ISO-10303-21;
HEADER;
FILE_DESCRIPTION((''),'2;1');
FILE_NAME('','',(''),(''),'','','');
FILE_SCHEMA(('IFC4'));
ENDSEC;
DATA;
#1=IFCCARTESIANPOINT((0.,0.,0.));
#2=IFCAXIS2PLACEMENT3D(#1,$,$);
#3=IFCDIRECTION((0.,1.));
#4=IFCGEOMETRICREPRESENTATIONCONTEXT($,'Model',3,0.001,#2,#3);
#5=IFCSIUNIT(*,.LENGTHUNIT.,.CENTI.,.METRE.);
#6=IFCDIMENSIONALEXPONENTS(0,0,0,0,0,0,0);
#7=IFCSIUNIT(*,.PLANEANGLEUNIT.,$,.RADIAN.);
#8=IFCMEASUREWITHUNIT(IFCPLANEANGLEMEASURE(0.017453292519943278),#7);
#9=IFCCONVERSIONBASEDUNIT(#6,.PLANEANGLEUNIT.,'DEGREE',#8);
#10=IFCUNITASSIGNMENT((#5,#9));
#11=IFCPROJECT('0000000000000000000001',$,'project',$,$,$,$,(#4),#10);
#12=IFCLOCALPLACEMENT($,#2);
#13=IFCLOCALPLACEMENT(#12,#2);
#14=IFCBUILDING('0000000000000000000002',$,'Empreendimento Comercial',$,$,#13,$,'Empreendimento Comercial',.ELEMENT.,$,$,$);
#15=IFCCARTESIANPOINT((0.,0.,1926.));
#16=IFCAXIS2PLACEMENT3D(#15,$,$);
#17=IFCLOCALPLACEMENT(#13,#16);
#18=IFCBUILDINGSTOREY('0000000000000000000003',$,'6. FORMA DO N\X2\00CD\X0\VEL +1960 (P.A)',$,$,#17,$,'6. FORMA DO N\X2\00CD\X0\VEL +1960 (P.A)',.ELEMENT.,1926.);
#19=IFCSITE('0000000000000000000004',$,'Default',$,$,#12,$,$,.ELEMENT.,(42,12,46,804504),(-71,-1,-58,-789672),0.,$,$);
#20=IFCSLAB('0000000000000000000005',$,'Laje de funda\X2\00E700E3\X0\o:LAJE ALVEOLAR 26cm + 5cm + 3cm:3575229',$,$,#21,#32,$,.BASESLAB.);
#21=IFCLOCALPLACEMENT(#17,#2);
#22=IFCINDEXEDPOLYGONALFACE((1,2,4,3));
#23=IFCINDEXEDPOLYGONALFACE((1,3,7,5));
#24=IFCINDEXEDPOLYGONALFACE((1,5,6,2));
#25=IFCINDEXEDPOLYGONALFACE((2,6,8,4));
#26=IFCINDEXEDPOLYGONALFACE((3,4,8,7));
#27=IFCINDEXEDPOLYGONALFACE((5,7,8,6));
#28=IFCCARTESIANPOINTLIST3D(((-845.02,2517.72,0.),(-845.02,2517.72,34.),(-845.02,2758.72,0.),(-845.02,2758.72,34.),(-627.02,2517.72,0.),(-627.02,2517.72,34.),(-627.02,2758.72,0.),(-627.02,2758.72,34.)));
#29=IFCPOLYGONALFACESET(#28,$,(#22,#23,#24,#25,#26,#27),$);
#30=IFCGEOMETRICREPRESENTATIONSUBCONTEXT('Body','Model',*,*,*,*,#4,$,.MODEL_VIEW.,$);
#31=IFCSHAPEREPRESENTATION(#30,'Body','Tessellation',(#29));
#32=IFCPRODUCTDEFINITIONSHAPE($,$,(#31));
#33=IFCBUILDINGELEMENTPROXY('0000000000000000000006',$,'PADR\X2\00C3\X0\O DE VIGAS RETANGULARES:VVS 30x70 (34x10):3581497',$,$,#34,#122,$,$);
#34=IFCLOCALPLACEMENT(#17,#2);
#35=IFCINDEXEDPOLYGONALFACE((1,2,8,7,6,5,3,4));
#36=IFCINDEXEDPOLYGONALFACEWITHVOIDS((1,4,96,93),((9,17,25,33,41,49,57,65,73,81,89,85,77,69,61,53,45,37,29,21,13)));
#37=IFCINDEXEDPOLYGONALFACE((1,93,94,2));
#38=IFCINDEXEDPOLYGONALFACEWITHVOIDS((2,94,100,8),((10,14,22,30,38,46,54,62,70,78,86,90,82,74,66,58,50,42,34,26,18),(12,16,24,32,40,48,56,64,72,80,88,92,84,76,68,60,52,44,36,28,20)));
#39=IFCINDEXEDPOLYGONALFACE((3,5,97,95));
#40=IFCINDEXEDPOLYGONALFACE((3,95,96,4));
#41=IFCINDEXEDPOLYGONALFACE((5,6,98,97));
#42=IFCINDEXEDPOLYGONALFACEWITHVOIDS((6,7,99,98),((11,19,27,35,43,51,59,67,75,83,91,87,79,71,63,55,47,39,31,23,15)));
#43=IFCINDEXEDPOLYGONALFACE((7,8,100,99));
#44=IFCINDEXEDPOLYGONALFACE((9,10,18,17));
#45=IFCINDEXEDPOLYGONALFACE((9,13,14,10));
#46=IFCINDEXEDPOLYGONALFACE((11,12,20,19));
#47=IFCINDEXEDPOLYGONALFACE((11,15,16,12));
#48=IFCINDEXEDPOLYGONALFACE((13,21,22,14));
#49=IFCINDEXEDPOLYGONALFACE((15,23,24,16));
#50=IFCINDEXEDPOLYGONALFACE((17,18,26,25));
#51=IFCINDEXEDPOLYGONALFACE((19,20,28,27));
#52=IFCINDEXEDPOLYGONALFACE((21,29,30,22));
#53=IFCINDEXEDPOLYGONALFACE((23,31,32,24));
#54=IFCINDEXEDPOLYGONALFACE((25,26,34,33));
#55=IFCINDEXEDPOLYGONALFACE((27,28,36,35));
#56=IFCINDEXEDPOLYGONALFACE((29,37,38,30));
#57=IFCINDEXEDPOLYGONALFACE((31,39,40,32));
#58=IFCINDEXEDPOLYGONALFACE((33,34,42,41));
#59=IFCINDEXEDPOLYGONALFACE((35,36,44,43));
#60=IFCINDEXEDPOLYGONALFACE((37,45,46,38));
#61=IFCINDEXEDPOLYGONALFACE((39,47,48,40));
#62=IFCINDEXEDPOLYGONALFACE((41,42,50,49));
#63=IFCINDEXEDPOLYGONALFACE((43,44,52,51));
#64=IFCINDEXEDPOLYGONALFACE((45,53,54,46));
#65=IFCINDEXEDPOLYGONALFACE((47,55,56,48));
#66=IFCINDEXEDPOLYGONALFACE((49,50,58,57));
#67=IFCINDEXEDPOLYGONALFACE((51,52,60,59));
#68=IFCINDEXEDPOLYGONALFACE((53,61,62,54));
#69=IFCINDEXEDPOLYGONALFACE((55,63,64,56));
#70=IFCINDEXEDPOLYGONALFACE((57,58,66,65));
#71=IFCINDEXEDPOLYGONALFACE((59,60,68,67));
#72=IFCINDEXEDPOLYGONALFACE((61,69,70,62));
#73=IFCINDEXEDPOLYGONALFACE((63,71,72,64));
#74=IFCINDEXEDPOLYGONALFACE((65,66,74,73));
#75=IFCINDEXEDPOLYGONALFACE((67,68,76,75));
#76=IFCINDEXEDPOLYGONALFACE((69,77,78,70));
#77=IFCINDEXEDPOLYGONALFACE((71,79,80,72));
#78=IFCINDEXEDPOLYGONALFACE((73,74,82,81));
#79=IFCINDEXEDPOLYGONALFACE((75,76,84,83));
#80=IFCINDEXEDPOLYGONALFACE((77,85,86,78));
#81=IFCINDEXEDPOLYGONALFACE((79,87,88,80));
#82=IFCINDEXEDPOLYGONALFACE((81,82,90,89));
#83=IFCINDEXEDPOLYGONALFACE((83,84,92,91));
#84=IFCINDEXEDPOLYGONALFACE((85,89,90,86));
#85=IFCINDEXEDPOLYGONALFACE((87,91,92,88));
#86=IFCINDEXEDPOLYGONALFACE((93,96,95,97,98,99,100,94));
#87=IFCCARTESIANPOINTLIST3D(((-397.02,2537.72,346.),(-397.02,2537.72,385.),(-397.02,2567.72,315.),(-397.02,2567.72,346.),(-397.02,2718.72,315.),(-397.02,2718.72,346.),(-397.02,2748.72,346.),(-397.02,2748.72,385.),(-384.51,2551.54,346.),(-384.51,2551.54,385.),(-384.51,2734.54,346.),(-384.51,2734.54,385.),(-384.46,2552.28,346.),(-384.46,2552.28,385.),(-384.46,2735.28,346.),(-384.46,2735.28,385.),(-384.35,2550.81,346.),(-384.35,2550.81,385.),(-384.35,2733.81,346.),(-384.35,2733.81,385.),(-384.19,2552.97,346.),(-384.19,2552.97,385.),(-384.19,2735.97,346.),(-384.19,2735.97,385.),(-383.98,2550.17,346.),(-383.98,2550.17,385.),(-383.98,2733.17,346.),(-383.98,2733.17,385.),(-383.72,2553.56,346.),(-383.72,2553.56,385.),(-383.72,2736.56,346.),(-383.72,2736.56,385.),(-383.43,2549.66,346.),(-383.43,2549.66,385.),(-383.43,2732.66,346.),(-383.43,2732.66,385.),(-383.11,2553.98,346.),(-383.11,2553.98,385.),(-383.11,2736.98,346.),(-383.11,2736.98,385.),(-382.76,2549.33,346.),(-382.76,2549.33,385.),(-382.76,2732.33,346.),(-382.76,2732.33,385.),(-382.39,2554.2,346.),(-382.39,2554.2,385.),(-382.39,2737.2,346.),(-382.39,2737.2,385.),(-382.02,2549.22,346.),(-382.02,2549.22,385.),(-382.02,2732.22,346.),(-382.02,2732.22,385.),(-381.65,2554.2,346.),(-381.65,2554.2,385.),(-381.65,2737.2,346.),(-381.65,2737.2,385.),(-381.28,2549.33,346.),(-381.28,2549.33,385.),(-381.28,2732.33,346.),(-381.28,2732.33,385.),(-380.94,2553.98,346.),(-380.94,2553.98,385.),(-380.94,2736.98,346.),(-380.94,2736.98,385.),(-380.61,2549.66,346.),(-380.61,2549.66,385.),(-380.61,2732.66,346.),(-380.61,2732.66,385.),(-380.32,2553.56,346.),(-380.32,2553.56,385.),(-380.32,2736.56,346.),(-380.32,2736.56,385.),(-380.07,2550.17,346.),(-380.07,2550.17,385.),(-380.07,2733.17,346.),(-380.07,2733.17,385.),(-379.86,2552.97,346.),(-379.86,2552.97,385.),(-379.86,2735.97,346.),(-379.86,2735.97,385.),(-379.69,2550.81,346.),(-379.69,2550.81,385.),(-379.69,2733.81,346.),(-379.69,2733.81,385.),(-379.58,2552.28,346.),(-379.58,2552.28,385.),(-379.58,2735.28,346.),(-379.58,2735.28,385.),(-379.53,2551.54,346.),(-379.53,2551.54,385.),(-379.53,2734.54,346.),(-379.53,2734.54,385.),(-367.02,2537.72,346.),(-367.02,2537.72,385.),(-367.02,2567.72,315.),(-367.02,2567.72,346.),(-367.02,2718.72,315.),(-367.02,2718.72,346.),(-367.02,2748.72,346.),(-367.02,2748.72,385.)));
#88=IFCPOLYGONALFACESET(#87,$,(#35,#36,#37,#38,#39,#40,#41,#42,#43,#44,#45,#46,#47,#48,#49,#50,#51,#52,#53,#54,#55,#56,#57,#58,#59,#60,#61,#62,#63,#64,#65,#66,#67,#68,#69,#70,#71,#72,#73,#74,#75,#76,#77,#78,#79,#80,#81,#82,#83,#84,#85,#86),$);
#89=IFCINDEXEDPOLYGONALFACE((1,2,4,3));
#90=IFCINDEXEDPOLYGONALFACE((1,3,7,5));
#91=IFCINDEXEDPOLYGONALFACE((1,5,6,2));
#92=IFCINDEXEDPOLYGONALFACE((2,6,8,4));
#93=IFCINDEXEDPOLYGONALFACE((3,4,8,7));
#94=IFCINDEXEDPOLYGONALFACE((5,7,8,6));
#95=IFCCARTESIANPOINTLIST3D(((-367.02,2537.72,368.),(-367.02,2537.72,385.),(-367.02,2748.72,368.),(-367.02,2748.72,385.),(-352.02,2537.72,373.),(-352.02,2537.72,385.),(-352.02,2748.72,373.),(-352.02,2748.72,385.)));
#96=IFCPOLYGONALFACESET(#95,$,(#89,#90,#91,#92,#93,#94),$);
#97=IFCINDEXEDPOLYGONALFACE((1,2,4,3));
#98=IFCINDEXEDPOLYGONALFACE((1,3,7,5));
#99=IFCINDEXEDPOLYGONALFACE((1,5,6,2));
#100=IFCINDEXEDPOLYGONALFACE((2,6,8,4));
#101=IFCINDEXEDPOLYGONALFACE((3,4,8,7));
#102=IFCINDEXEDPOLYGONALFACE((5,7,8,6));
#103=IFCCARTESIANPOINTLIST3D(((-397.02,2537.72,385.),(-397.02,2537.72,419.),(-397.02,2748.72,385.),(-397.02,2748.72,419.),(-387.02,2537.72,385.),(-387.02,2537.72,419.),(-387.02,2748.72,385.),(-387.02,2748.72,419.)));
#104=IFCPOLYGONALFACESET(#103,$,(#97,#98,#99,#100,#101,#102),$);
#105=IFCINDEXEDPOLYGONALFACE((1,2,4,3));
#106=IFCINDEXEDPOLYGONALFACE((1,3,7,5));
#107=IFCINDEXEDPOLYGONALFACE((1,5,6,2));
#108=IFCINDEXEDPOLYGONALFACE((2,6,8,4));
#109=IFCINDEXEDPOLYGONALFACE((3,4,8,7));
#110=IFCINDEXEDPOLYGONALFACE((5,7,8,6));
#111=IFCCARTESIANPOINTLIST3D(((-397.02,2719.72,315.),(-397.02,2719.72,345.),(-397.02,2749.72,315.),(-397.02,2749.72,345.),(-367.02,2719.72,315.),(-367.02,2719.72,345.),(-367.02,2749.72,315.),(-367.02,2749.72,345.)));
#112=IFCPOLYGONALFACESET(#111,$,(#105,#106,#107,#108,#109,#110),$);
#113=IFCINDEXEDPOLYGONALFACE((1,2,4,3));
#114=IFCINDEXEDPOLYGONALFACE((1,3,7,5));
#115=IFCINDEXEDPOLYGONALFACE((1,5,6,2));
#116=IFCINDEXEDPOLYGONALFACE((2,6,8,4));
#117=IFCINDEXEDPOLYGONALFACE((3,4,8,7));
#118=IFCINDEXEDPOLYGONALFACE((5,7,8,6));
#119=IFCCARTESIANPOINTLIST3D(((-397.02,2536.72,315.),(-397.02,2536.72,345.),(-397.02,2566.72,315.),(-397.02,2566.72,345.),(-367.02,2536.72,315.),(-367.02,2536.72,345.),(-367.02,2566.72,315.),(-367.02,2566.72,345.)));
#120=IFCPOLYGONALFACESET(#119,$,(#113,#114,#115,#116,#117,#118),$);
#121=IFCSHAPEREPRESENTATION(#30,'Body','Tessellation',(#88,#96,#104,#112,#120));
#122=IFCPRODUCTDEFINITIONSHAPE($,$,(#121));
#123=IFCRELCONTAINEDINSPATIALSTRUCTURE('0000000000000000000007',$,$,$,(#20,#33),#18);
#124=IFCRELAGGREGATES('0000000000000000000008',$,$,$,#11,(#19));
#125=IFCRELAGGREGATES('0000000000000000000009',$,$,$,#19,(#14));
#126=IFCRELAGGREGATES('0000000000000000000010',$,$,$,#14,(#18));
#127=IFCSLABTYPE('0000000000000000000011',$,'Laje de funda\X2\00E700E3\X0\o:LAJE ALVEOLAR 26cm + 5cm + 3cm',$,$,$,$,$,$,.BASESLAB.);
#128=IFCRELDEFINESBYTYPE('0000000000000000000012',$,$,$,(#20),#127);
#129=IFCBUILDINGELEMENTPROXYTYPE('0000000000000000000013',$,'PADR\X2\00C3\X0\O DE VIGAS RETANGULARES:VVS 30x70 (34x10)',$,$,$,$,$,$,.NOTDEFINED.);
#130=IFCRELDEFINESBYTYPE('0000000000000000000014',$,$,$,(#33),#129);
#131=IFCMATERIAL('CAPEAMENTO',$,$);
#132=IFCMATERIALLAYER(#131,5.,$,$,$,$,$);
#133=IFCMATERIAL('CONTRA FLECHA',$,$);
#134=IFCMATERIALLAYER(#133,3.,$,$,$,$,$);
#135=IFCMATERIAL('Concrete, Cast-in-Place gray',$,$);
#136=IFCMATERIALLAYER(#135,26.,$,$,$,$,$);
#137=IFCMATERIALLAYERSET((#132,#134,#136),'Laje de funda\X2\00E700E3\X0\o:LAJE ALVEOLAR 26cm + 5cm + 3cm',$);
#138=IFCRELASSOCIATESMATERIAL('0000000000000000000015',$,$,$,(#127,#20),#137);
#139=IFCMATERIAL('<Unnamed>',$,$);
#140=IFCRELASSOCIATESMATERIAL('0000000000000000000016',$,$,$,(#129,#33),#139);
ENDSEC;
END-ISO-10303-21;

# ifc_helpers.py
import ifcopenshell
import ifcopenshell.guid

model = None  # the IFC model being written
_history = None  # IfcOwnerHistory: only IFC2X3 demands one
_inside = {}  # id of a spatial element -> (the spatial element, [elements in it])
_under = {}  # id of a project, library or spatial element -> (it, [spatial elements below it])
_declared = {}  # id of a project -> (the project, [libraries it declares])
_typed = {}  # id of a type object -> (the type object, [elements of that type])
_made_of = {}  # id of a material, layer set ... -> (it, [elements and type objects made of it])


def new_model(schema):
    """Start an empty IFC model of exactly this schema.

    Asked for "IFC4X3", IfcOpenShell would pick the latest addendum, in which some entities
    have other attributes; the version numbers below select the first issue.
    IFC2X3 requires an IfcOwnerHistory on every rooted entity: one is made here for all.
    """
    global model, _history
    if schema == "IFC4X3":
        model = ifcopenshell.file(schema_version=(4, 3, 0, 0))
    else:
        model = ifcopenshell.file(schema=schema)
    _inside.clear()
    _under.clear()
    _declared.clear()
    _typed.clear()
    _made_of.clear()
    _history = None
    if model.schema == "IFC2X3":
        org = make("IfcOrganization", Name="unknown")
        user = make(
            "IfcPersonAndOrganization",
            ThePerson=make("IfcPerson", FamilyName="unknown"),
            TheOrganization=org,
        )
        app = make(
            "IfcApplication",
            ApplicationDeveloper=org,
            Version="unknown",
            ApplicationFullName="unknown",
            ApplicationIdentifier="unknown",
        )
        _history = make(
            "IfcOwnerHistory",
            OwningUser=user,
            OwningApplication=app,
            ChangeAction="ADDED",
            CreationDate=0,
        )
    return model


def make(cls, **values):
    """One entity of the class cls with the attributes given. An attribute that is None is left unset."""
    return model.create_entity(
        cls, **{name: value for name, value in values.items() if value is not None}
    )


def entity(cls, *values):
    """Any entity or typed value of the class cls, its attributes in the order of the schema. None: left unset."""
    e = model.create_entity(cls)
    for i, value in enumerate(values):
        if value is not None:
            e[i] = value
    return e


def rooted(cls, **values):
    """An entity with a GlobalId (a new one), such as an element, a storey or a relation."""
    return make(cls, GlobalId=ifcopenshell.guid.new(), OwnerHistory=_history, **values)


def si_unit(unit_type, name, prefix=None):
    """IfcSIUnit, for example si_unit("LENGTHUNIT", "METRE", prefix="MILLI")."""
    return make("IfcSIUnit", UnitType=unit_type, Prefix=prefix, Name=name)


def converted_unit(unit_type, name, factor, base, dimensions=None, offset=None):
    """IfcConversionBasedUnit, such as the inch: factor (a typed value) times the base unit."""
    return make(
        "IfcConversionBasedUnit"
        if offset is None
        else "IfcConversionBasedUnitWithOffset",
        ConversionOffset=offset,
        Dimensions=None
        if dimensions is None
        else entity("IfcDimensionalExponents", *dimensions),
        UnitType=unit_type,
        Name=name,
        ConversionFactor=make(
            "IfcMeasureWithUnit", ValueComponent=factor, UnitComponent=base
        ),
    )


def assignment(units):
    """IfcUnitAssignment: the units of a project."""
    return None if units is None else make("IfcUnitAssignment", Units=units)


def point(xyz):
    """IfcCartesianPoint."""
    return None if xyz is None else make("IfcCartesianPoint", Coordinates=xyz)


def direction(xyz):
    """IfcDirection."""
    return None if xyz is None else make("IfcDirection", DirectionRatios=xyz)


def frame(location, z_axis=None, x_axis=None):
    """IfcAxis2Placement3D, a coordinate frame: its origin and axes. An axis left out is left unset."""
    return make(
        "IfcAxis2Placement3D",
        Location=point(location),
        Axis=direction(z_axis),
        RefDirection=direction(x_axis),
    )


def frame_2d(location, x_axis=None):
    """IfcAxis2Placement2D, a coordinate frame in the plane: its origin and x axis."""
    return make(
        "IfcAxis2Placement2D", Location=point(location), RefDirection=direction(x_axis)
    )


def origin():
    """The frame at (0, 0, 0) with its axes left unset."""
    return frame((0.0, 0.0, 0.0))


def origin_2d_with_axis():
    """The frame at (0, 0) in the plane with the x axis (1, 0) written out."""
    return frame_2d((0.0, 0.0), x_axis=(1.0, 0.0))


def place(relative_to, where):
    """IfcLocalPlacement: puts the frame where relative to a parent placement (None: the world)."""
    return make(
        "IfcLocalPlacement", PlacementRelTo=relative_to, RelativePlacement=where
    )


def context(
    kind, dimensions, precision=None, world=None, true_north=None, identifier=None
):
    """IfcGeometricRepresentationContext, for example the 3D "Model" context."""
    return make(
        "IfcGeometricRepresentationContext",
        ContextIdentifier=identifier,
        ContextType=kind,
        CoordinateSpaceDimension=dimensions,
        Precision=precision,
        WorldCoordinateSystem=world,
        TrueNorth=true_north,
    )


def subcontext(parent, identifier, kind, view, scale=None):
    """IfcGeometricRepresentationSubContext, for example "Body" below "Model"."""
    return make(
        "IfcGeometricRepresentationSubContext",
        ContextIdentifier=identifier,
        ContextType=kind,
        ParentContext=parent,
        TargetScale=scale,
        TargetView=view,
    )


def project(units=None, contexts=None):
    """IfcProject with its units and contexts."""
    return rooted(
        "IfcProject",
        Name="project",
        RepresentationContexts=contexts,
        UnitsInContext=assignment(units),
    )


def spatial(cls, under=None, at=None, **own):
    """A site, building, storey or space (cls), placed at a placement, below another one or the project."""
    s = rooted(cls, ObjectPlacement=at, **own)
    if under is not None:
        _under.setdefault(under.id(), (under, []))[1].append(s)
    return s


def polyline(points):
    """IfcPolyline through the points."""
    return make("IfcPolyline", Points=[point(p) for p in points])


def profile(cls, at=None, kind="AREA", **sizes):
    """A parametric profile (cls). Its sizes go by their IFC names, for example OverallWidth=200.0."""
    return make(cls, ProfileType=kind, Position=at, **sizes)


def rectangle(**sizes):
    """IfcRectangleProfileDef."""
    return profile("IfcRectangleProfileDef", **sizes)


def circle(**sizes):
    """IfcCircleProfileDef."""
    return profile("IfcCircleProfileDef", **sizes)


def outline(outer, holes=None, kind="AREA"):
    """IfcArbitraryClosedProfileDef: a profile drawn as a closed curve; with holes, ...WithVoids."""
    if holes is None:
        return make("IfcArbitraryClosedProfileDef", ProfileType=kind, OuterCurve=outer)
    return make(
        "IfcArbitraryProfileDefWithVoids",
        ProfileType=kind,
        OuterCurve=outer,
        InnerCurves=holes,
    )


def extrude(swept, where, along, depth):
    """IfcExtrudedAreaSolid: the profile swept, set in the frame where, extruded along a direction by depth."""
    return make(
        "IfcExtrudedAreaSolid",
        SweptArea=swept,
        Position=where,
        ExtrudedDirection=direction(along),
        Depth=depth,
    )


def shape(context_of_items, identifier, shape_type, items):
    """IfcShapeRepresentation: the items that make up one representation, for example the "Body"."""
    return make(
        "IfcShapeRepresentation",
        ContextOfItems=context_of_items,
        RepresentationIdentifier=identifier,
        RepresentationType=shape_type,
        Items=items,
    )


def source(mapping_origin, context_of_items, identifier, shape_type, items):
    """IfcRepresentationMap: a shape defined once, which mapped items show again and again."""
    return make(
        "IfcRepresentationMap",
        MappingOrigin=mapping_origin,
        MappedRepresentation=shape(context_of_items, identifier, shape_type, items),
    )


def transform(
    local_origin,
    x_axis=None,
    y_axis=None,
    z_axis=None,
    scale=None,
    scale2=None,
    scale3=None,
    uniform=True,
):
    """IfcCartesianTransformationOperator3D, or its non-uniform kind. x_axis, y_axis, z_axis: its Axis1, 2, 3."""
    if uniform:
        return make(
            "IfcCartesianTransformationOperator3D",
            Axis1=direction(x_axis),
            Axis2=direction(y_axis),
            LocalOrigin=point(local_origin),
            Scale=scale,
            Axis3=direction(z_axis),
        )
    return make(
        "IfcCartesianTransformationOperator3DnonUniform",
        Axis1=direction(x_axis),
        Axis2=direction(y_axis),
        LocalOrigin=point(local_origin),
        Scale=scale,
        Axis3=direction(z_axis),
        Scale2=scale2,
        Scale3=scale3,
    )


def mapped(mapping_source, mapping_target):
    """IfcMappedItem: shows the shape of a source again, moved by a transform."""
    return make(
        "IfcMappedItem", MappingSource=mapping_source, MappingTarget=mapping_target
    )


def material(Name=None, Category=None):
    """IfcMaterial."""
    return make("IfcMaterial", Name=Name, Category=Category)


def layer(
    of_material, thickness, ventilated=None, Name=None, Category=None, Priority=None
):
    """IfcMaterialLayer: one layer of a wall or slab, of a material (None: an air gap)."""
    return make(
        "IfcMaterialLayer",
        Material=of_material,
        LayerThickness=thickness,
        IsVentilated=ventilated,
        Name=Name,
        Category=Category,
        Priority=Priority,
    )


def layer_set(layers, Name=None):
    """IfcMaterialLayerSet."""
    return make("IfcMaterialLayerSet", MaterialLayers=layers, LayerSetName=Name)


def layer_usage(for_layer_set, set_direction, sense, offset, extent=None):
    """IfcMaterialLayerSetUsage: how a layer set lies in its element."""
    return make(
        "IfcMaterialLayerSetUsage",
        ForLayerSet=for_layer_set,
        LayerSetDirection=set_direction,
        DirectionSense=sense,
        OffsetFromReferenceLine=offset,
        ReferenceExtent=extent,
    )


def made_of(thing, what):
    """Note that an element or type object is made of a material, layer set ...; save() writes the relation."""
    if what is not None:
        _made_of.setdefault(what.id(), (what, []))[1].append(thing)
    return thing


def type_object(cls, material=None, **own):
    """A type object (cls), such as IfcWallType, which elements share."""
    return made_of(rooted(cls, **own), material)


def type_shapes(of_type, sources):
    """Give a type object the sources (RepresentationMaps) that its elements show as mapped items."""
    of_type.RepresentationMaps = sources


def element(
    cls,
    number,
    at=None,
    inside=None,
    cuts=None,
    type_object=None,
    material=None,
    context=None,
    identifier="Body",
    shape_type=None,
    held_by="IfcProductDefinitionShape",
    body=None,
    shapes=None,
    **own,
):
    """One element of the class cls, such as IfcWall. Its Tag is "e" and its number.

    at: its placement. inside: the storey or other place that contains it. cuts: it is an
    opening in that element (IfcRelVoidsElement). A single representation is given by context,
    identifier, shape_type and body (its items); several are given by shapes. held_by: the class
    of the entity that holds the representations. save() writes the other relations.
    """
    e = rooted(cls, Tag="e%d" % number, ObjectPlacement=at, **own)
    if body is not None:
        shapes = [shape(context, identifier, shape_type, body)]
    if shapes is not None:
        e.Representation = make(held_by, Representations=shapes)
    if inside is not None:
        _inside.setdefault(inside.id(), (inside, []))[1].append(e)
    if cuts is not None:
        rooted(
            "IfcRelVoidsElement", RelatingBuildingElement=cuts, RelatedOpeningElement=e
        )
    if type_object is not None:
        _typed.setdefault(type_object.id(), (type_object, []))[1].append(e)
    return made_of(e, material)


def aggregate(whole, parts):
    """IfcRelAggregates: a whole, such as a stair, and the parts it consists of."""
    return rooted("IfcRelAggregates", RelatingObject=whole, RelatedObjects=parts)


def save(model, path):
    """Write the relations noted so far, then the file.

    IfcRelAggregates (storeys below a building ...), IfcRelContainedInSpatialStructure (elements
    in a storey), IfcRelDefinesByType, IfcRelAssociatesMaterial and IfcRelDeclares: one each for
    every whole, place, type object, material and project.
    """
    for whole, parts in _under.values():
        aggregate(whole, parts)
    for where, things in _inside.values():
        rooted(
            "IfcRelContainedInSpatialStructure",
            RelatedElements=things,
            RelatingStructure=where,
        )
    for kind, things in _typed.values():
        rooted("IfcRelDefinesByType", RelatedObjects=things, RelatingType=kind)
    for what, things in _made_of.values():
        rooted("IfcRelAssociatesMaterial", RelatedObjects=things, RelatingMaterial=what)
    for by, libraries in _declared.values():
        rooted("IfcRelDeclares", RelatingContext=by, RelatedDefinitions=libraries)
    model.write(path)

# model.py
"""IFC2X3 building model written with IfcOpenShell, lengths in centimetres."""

from ifc_helpers import new_model, entity, si_unit, converted_unit, direction, frame, frame_2d, origin, origin_2d_with_axis, place, context, subcontext, project, spatial, polyline, rectangle, circle, outline, extrude, source, transform, mapped, material, layer, layer_set, layer_usage, type_object, type_shapes, element, save


model = new_model("IFC2X3")

# Units and contexts
model_context = context("Model", 3, precision=0.001, world=origin(), true_north=direction((0.0, 1.0)))
body_context = subcontext(model_context, "Body", "Model", "MODEL_VIEW")
ifc_project = project(units=[si_unit("LENGTHUNIT", "METRE", prefix="CENTI"), converted_unit("PLANEANGLEUNIT", "DEGREE", entity("IfcPlaneAngleMeasure", 0.017453292519943278), si_unit("PLANEANGLEUNIT", "RADIAN"), dimensions=[0, 0, 0, 0, 0, 0, 0])], contexts=[model_context])

# Site, building, storey
site_placement = place(None, origin())
site = spatial("IfcSite", under=ifc_project, at=site_placement, Name="Default", CompositionType="ELEMENT", RefLatitude=(42, 12, 46, 804504), RefLongitude=(-71, -1, -58, -789672), RefElevation=0.0)
building_placement = place(site_placement, origin())
building = spatial("IfcBuilding", under=site, at=building_placement, Name="Empreendimento Comercial", LongName="Empreendimento Comercial", CompositionType="ELEMENT")
storey_placement = place(building_placement, frame((0.0, 0.0, 1926.0)))
storey = spatial("IfcBuildingStorey", under=building, at=storey_placement, Name="6. FORMA DO NÍVEL +1960 (P.A)", LongName="6. FORMA DO NÍVEL +1960 (P.A)", CompositionType="ELEMENT", Elevation=1926.0)

# Slab
ifc_material_1 = material(Name="CAPEAMENTO")
ifc_layer_1 = layer(ifc_material_1, 5.0)
ifc_material_2 = material(Name="CONTRA FLECHA")
ifc_layer_2 = layer(ifc_material_2, 3.0)
ifc_material_3 = material(Name="Concrete, Cast-in-Place gray")
ifc_layer_3 = layer(ifc_material_3, 26.0)
ifc_layer_set_1 = layer_set([ifc_layer_1, ifc_layer_2, ifc_layer_3], Name="Laje de fundação:LAJE ALVEOLAR 26cm + 5cm + 3cm")
ifc_layer_usage_1 = layer_usage(ifc_layer_set_1, "AXIS3", "POSITIVE", 0.0)
slab_type_1 = type_object("IfcSlabType", Name="Laje de fundação:LAJE ALVEOLAR 26cm + 5cm + 3cm", PredefinedType="BASESLAB", material=ifc_layer_set_1)
slab_1_placement = place(storey_placement, origin())
element("IfcSlab", 1, at=slab_1_placement, inside=storey, type_object=slab_type_1, material=ifc_layer_usage_1, Name="Laje de fundação:LAJE ALVEOLAR 26cm + 5cm + 3cm:3575229", PredefinedType="BASESLAB", context=body_context, shape_type="SweptSolid", body=[
    extrude(rectangle(XDim=241.0, YDim=218.0, at=origin_2d_with_axis()), frame((-736.02, 2638.22, 34.0), z_axis=(0.0, 0.0, -1.0), x_axis=(0.0, 1.0, 0.0)), (0.0, 0.0, 1.0), 34.0),
])

# Building element proxy, openings
ifc_material_4 = material(Name="<Unnamed>")
building_element_proxy_type_1 = type_object("IfcBuildingElementProxyType", Name="PADRÃO DE VIGAS RETANGULARES:VVS 30x70 (34x10)", PredefinedType="NOTDEFINED", material=ifc_material_4)
shared_shape_1 = source(origin(), body_context, "Body", "SweptSolid", [
    extrude(outline(polyline([(-105.5, -37.0), (105.5, -37.0), (105.5, 2.0), (75.5, 2.0), (75.5, 33.0), (-75.5, 33.0), (-75.5, 2.0), (-105.5, 2.0), (-105.5, -37.0)])), frame((-397.02, 2643.22, 2274.0), z_axis=(1.0, 0.0, 0.0), x_axis=(0.0, -1.0, 0.0)), (0.0, 0.0, 1.0), 30.0),
    extrude(outline(polyline([(-7.25, -7.5), (4.75, -7.5), (9.75, 7.5), (-7.25, 7.5), (-7.25, -7.5)])), frame((-359.52, 2537.72, 2303.75), z_axis=(0.0, 1.0, 0.0), x_axis=(0.0, 0.0, -1.0)), (0.0, 0.0, 1.0), 211.0),
    extrude(rectangle(XDim=211.0, YDim=10.0, at=frame_2d((0.0, 0.0), x_axis=(1.0, 0.0))), frame((-392.02, 2643.22, 2311.0), z_axis=(0.0, 0.0, 1.0), x_axis=(0.0, 1.0, 0.0)), (0.0, 0.0, 1.0), 34.0),
    extrude(rectangle(XDim=30.0, YDim=30.0, at=frame_2d((0.0, 0.0), x_axis=(1.0, 0.0))), frame((-382.02, 2734.72, 2241.0), z_axis=(0.0, 0.0, 1.0), x_axis=(0.0, 1.0, 0.0)), (0.0, 0.0, 1.0), 30.0),
    extrude(rectangle(XDim=30.0, YDim=30.0, at=origin_2d_with_axis()), frame((-382.02, 2551.72, 2241.0), z_axis=(0.0, 0.0, 1.0), x_axis=(0.0, 1.0, 0.0)), (0.0, 0.0, 1.0), 30.0),
])
type_shapes(building_element_proxy_type_1, [shared_shape_1])
proxy_1_placement = place(storey_placement, frame((0.0, 0.0, -1926.0)))
proxy_1 = element("IfcBuildingElementProxy", 2, at=proxy_1_placement, inside=storey, type_object=building_element_proxy_type_1, material=ifc_material_4, Name="PADRÃO DE VIGAS RETANGULARES:VVS 30x70 (34x10):3581497", context=body_context, shape_type="MappedRepresentation", body=[
    mapped(shared_shape_1, transform((0.0, 0.0, 0.0), scale=1.0)),
])
opening_1_placement = place(storey_placement, frame((0.0, 0.0, -1926.0)))
element("IfcOpeningElement", 3, at=opening_1_placement, cuts=proxy_1, ObjectType="Opening", context=body_context, shape_type="SweptSolid", body=[
    extrude(circle(Radius=2.5, at=origin_2d_with_axis()), frame((-382.02, 2551.72, 2272.0), z_axis=(0.0, 0.0, 1.0), x_axis=(0.0, -1.0, 0.0)), (0.0, 0.0, 1.0), 39.0),
])
opening_2_placement = place(storey_placement, frame((0.0, 0.0, -1926.0)))
element("IfcOpeningElement", 4, at=opening_2_placement, cuts=proxy_1, ObjectType="Opening", context=body_context, shape_type="SweptSolid", body=[
    extrude(circle(Radius=2.5, at=origin_2d_with_axis()), frame((-382.02, 2734.72, 2272.0), z_axis=(0.0, 0.0, 1.0), x_axis=(0.0, -1.0, 0.0)), (0.0, 0.0, 1.0), 39.0),
])

save(model, "model.ifc")
